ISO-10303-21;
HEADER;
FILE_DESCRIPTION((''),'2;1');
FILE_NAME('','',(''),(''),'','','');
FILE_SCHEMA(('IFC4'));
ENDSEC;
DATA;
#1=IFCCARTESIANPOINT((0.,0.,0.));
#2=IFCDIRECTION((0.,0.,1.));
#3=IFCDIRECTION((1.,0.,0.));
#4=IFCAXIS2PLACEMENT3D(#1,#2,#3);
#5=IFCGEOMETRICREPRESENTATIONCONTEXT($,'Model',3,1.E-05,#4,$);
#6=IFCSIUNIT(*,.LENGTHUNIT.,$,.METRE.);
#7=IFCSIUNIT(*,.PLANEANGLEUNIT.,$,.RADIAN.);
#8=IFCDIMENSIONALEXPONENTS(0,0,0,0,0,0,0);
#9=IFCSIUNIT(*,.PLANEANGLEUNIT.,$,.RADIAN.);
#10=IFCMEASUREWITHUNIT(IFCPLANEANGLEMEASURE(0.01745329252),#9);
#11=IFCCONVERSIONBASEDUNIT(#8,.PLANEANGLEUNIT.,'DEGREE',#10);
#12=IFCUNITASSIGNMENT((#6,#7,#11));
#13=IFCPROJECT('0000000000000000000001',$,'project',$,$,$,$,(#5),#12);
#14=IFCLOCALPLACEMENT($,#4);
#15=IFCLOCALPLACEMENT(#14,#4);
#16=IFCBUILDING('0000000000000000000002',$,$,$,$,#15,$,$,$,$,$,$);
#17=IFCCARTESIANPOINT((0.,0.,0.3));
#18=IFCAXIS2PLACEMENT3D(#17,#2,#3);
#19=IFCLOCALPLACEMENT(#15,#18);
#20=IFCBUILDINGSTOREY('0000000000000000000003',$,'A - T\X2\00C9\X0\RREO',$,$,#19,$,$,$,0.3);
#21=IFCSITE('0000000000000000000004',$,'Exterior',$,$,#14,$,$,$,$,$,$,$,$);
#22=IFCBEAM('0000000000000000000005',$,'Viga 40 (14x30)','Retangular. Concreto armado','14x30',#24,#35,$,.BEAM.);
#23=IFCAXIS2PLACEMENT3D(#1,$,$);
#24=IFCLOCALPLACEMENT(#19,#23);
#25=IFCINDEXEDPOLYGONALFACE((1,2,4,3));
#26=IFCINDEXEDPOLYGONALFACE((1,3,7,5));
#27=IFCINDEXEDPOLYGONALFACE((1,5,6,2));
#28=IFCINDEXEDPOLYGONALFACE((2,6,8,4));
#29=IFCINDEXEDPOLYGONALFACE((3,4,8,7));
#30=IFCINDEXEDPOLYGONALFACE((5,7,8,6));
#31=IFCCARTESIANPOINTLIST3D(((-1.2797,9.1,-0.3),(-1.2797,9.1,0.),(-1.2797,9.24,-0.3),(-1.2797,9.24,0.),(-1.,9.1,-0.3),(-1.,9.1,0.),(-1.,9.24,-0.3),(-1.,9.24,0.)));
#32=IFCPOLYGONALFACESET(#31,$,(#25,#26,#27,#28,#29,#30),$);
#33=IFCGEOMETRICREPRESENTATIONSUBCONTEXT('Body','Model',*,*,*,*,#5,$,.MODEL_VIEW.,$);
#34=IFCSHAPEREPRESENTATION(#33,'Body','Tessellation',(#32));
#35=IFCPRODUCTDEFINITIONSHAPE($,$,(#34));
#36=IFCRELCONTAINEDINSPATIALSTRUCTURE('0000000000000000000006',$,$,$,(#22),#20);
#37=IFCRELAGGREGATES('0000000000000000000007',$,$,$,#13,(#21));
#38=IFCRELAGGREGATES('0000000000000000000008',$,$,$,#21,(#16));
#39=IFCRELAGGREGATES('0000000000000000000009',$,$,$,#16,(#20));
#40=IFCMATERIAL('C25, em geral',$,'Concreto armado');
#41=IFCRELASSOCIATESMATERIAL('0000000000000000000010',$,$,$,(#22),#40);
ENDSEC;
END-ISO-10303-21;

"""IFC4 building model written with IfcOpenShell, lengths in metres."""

from ifc_helpers import new_model, entity, si_unit, converted_unit, frame, frame_2d, origin_with_axes, place, context, subcontext, project, spatial, rectangle, extrude, material, element, save


model = new_model("IFC4")

# Units and contexts
model_context = context("Model", 3, precision=1e-05, world=origin_with_axes())
body_context = subcontext(model_context, "Body", "Model", "MODEL_VIEW")
ifc_project = project(units=[si_unit("LENGTHUNIT", "METRE"), si_unit("PLANEANGLEUNIT", "RADIAN"), converted_unit("PLANEANGLEUNIT", "DEGREE", entity("IfcPlaneAngleMeasure", 0.01745329252), si_unit("PLANEANGLEUNIT", "RADIAN"), dimensions=[0, 0, 0, 0, 0, 0, 0])], contexts=[model_context])

# Site, building, storey
site_placement = place(None, origin_with_axes())
site = spatial("IfcSite", under=ifc_project, at=site_placement, Name="Exterior")
building_placement = place(site_placement, origin_with_axes())
building = spatial("IfcBuilding", under=site, at=building_placement)
storey_placement = place(building_placement, frame((0.0, 0.0, 0.3), z_axis=(0.0, 0.0, 1.0), x_axis=(1.0, 0.0, 0.0)))
storey = spatial("IfcBuildingStorey", under=building, at=storey_placement, Name="A - TÉRREO", Elevation=0.3)

# Shared definitions
ifc_material = material(Name="C25, em geral", Category="Concreto armado")

# Beam
beam_1_placement = place(storey_placement, frame((-1.0, 9.17, 0.0), z_axis=(-1.0, 0.0, 0.0), x_axis=(0.0, -1.0, 0.0)))
element("IfcBeam", 1, at=beam_1_placement, inside=storey, material=ifc_material, Name="Viga 40 (14x30)", Description="Retangular. Concreto armado", ObjectType="14x30", PredefinedType="BEAM", context=body_context, shape_type="SweptSolid", body=[
    extrude(rectangle(XDim=0.14, YDim=0.3, at=frame_2d((0.0, -0.15), x_axis=(1.0, 0.0))), origin_with_axes(), (0.0, 0.0, 1.0), 0.2797),
])

save(model, "model.ifc")
